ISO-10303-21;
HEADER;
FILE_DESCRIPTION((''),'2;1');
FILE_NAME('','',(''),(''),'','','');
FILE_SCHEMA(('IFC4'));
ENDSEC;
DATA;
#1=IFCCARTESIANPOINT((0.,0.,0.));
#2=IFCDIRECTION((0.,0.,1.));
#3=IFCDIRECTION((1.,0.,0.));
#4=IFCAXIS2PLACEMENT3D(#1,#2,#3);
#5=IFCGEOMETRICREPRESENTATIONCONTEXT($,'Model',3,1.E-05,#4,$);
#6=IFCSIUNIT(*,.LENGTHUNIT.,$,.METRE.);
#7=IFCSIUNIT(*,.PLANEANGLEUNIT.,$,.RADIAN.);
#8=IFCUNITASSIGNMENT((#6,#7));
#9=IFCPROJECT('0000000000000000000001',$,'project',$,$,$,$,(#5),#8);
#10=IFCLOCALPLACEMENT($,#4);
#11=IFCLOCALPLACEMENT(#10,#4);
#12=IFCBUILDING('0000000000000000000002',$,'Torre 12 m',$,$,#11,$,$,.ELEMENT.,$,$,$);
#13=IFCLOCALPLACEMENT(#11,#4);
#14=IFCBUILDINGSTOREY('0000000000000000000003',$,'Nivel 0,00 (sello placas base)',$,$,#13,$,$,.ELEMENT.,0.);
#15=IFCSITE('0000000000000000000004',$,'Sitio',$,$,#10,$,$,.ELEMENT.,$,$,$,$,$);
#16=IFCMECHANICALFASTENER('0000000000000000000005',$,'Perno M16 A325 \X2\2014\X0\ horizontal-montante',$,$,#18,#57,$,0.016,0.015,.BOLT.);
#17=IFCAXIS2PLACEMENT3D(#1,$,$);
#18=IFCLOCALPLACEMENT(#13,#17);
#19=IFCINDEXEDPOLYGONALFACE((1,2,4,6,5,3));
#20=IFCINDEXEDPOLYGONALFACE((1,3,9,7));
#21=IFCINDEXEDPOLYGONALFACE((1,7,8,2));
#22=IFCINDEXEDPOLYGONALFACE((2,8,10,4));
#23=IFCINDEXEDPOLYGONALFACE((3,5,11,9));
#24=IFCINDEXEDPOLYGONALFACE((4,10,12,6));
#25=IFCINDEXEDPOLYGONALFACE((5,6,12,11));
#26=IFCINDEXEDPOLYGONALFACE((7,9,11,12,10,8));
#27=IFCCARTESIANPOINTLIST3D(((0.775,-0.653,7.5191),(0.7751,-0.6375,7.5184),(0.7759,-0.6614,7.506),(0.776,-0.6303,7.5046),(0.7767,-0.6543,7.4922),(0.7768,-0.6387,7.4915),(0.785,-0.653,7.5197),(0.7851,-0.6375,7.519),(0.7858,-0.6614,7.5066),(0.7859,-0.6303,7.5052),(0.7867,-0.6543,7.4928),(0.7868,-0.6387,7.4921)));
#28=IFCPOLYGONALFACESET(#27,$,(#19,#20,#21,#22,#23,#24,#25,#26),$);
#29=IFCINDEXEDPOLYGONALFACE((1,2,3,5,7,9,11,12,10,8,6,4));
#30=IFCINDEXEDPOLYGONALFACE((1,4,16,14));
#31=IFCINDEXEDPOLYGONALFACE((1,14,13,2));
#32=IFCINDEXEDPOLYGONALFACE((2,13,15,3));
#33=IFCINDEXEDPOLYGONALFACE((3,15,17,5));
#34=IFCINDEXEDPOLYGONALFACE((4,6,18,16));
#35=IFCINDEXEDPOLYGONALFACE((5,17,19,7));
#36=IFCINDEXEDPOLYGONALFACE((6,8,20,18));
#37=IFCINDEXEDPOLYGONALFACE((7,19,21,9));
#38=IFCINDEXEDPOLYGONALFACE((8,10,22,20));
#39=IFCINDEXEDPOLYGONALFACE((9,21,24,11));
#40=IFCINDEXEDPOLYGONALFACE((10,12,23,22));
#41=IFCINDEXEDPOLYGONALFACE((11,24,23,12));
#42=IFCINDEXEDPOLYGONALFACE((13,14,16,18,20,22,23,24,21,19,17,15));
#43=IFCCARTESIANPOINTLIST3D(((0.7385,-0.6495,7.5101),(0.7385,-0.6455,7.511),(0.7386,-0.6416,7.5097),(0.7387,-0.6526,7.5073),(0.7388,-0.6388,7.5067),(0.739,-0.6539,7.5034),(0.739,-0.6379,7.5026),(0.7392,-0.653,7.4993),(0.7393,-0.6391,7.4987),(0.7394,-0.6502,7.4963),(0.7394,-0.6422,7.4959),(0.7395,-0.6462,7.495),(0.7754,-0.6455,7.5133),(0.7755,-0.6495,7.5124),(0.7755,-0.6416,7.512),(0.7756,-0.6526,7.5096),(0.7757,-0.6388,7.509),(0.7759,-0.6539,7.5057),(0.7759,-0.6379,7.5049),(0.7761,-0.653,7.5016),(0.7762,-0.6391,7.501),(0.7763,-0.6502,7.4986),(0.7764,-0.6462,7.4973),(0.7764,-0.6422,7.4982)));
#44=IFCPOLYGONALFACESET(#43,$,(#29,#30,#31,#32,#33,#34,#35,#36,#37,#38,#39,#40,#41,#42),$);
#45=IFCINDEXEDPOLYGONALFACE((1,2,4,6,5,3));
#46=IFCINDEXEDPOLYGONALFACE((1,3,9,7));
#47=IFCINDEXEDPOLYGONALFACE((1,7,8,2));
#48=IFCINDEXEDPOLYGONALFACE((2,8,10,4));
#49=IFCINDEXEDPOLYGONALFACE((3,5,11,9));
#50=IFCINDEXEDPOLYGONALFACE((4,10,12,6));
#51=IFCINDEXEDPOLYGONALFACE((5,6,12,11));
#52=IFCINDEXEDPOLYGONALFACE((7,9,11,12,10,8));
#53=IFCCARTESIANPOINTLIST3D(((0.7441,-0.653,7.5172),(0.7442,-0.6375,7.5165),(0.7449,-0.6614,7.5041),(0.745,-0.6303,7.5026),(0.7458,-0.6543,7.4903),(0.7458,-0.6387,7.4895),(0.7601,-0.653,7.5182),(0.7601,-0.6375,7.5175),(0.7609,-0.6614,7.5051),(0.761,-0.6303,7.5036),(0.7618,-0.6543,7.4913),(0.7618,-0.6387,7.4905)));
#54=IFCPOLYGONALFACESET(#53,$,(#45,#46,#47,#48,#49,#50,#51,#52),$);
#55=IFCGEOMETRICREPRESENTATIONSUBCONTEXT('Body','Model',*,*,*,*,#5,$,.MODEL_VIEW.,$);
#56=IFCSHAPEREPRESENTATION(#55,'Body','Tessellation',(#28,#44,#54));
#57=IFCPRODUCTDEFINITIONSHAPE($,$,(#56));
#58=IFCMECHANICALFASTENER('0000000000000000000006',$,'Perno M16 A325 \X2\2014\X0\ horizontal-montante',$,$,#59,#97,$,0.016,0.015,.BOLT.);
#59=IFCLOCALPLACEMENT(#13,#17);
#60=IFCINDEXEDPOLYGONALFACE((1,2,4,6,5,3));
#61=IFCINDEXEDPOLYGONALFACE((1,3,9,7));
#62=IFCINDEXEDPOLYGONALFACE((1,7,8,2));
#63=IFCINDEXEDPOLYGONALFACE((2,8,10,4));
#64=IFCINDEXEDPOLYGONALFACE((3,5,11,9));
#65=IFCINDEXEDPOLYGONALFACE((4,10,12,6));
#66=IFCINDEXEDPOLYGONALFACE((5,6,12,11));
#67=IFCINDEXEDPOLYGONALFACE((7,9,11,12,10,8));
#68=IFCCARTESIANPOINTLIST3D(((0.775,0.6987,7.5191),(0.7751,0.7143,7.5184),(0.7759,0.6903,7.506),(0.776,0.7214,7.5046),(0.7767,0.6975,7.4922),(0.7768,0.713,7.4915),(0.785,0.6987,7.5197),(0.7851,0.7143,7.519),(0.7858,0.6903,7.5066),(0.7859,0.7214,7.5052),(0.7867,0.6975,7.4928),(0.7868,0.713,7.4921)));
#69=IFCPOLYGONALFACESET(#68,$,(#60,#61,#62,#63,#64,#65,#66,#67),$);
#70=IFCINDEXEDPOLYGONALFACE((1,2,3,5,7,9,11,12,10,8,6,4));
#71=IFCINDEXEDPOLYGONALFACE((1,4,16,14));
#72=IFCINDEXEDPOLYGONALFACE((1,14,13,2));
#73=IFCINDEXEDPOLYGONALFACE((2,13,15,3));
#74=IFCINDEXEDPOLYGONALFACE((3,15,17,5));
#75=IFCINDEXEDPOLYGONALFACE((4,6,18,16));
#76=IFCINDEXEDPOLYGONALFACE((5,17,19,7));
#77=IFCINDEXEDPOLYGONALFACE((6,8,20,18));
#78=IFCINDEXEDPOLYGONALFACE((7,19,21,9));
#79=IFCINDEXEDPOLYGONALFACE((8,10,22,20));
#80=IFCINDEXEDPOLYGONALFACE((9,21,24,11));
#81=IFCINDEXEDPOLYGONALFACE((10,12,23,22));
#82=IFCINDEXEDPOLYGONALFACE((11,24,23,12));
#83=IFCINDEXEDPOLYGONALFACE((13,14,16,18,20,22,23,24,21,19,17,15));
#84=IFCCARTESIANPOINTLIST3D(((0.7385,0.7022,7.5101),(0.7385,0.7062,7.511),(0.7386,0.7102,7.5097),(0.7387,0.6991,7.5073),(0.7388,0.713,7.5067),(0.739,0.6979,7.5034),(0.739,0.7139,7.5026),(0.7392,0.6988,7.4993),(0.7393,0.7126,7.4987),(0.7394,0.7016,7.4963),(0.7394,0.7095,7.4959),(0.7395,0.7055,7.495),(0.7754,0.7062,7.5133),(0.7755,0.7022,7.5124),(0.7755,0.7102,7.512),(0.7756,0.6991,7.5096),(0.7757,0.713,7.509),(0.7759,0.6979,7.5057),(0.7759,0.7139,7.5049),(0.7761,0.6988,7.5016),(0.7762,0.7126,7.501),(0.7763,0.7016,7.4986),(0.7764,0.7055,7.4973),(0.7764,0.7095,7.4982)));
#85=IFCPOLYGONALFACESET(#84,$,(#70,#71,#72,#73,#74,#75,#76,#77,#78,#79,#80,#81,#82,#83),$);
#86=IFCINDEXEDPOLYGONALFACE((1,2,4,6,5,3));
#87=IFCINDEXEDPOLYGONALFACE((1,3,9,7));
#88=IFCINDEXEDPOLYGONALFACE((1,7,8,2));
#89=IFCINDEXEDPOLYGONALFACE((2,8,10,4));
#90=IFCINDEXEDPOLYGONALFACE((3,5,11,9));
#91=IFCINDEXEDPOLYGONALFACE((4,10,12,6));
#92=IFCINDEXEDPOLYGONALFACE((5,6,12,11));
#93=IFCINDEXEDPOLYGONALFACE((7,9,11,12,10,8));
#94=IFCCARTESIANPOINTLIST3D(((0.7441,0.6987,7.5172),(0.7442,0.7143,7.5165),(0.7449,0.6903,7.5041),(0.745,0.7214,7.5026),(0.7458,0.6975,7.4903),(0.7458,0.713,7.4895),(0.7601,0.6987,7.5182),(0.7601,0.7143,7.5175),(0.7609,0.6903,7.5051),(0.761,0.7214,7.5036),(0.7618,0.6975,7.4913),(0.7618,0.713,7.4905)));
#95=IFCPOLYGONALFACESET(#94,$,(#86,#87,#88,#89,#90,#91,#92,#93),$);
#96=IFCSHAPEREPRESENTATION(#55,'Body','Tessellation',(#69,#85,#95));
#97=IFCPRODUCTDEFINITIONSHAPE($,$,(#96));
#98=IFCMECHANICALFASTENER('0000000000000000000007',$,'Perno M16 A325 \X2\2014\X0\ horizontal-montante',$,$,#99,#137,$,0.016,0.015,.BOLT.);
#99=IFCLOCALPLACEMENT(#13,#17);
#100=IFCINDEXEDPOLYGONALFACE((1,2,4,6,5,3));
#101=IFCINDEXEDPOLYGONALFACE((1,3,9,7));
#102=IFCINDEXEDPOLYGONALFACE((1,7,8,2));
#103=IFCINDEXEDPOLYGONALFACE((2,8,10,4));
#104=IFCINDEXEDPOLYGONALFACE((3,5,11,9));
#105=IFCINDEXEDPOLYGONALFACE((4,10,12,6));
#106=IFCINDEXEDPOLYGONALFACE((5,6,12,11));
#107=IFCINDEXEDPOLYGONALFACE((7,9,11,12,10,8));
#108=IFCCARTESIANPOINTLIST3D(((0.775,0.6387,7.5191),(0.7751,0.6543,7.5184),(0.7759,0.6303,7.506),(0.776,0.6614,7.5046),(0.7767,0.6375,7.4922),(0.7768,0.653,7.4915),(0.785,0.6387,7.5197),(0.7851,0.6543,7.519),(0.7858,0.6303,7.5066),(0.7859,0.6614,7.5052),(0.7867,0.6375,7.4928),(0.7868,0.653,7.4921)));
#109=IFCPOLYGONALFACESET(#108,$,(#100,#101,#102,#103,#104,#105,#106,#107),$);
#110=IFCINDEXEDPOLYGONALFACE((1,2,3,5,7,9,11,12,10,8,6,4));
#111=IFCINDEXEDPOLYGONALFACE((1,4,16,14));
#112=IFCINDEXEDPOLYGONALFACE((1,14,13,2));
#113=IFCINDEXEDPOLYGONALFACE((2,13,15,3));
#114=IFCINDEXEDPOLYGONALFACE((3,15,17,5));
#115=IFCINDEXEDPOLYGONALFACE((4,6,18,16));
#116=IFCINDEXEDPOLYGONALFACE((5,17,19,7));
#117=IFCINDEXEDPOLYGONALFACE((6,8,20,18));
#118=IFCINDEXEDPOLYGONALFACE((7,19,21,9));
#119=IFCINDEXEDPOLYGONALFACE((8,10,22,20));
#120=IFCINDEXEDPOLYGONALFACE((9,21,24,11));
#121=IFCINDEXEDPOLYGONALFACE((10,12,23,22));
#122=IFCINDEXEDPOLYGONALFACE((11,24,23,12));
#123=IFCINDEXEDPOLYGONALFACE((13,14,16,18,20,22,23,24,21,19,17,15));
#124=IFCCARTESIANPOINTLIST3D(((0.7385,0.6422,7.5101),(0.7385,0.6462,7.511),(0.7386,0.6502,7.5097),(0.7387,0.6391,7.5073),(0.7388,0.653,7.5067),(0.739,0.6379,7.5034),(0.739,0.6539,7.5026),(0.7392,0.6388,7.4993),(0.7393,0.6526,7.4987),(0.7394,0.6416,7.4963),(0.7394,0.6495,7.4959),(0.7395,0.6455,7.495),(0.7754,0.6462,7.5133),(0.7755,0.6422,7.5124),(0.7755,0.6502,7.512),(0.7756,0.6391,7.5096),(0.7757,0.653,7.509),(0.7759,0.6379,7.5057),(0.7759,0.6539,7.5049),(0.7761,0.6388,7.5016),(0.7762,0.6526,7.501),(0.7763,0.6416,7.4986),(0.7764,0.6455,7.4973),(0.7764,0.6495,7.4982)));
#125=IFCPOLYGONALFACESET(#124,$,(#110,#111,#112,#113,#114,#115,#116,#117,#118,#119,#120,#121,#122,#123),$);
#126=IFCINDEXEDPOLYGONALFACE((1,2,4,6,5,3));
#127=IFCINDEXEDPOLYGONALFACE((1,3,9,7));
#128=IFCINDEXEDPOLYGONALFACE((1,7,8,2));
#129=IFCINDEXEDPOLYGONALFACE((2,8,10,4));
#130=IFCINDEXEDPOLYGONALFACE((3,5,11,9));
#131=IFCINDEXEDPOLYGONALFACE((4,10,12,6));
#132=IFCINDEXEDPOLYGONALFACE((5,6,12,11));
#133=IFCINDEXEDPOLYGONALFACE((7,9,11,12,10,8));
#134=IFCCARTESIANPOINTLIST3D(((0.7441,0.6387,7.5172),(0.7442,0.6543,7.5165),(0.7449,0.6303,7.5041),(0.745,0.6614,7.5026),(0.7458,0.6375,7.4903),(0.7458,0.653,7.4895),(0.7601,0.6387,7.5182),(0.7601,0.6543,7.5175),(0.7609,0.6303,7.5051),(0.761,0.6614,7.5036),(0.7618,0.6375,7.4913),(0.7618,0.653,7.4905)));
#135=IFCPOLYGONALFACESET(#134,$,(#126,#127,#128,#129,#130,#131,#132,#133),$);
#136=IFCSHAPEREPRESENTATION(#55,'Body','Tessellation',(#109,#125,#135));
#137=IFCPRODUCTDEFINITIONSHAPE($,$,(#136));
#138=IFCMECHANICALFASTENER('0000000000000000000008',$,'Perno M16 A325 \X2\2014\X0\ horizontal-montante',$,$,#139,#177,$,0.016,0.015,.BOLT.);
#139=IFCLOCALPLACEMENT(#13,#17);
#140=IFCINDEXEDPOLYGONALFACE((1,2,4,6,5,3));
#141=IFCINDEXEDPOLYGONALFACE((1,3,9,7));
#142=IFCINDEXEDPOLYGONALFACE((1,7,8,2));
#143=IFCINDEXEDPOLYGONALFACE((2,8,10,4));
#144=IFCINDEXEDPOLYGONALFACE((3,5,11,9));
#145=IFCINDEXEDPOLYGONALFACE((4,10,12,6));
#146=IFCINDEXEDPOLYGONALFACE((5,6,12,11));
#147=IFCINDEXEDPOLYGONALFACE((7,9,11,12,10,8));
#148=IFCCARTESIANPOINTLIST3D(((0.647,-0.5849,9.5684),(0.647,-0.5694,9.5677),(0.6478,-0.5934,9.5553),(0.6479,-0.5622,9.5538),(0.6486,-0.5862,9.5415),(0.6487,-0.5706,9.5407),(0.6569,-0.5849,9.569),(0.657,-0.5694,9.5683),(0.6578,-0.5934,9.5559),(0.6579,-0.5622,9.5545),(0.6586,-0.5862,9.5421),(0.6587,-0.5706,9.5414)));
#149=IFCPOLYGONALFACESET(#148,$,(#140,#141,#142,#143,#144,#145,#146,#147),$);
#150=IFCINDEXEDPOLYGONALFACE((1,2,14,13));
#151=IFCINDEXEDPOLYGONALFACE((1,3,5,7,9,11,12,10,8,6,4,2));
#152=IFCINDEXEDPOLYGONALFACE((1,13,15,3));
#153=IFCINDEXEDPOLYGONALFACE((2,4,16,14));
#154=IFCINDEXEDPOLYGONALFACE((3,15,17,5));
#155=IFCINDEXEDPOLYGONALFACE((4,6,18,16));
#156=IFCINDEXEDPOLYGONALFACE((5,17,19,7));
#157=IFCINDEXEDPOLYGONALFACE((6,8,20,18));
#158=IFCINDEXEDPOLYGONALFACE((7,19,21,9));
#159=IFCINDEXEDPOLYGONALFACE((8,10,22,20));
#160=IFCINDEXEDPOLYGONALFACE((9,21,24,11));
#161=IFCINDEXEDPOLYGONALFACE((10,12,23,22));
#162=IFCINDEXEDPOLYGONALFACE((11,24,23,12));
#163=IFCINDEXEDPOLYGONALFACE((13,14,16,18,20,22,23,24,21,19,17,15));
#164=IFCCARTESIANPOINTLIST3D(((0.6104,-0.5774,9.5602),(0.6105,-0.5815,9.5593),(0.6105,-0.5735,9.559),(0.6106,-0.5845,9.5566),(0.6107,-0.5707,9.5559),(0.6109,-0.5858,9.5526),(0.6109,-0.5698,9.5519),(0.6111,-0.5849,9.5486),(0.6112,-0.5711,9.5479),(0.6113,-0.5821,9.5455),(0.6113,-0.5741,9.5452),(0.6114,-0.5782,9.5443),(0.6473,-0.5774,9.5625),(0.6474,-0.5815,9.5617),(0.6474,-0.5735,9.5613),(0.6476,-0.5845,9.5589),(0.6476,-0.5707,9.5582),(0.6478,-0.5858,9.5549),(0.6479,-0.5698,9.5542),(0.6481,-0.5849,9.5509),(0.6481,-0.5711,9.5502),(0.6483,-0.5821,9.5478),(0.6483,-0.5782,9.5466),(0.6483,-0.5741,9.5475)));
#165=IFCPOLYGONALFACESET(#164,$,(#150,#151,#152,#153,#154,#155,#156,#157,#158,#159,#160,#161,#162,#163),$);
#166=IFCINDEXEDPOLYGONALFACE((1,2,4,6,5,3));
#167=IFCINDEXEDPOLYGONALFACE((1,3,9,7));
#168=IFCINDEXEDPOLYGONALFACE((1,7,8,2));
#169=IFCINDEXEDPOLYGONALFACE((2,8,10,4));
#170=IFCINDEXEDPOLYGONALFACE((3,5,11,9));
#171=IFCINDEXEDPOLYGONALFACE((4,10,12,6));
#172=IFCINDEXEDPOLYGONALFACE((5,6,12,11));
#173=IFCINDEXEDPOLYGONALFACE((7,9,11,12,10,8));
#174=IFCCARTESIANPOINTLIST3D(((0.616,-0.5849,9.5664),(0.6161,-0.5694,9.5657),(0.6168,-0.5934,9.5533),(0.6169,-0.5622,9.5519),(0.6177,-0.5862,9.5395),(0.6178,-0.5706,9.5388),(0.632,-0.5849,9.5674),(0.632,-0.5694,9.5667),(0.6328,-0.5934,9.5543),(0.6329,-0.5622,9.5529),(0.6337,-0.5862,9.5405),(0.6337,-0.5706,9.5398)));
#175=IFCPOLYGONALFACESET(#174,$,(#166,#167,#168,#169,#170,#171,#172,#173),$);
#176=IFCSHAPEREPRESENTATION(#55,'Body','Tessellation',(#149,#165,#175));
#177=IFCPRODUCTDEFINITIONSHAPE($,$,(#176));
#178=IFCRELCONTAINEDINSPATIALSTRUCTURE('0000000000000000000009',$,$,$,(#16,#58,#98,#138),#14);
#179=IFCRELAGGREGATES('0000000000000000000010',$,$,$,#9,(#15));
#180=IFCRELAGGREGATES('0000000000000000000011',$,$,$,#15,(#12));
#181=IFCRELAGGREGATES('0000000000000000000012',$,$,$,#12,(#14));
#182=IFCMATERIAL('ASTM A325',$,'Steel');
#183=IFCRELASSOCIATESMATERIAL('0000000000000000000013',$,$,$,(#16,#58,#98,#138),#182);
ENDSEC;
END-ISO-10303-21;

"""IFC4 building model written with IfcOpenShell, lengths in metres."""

from ifc_helpers import new_model, si_unit, frame, origin_with_axes, place, context, subcontext, project, spatial, polyline, outline, extrude, material, element, save


model = new_model("IFC4")

# Units and contexts
model_context = context("Model", 3, precision=1e-05, world=origin_with_axes())
body_context = subcontext(model_context, "Body", "Model", "MODEL_VIEW")
ifc_project = project(units=[si_unit("LENGTHUNIT", "METRE"), si_unit("PLANEANGLEUNIT", "RADIAN")], contexts=[model_context])

# Site, building, storey
site_placement = place(None, origin_with_axes())
site = spatial("IfcSite", under=ifc_project, at=site_placement, Name="Sitio", CompositionType="ELEMENT")
building_placement = place(site_placement, origin_with_axes())
building = spatial("IfcBuilding", under=site, at=building_placement, Name="Torre 12 m", CompositionType="ELEMENT")
storey_placement = place(building_placement, origin_with_axes())
storey = spatial("IfcBuildingStorey", under=building, at=storey_placement, Name="Nivel 0,00 (sello placas base)", CompositionType="ELEMENT", Elevation=0.0)

# Shared definitions
placement = place(storey_placement, origin_with_axes())

# Mechanical fasteners
ifc_material_1 = material(Name="ASTM A325", Category="Steel")
element("IfcMechanicalFastener", 1, at=placement, inside=storey, material=ifc_material_1, Name="Perno M16 A325 — horizontal-montante", NominalDiameter=0.016, NominalLength=0.015, PredefinedType="BOLT", context=body_context, shape_type="SweptSolid", body=[
    extrude(outline(polyline([(0.0135, 0.0078), (0.0, 0.0156), (-0.0135, 0.0078), (-0.0135, -0.0078), (0.0, -0.0156), (0.0135, -0.0078), (0.0135, 0.0078)])), frame((0.7859, -0.6459, 7.5059), z_axis=(-0.998053, 0.0, -0.062378), x_axis=(0.033672, 0.841794, -0.538748)), (0.0, 0.0, 1.0), 0.01),
    extrude(outline(polyline([(0.008, 0.0), (0.0069, 0.004), (0.004, 0.0069), (0.0, 0.008), (-0.004, 0.0069), (-0.0069, 0.004), (-0.008, 0.0), (-0.0069, -0.004), (-0.004, -0.0069), (0.0, -0.008), (0.004, -0.0069), (0.0069, -0.004), (0.008, 0.0)])), frame((0.7759, -0.6459, 7.5053), z_axis=(-0.998053, 0.0, -0.062378), x_axis=(0.033672, 0.841794, -0.538748)), (0.0, 0.0, 1.0), 0.037),
    extrude(outline(polyline([(0.0135, 0.0078), (0.0, 0.0156), (-0.0135, 0.0078), (-0.0135, -0.0078), (0.0, -0.0156), (0.0135, -0.0078), (0.0135, 0.0078)])), frame((0.7609, -0.6459, 7.5044), z_axis=(-0.998053, 0.0, -0.062378), x_axis=(0.033672, 0.841794, -0.538748)), (0.0, 0.0, 1.0), 0.016),
])
element("IfcMechanicalFastener", 2, at=placement, inside=storey, material=ifc_material_1, Name="Perno M16 A325 — horizontal-montante", NominalDiameter=0.016, NominalLength=0.015, PredefinedType="BOLT", context=body_context, shape_type="SweptSolid", body=[
    extrude(outline(polyline([(0.0135, 0.0078), (0.0, 0.0156), (-0.0135, 0.0078), (-0.0135, -0.0078), (0.0, -0.0156), (0.0135, -0.0078), (0.0135, 0.0078)])), frame((0.7859, 0.7059, 7.5059), z_axis=(-0.998053, 0.0, -0.062378), x_axis=(0.033672, 0.841794, -0.538748)), (0.0, 0.0, 1.0), 0.01),
    extrude(outline(polyline([(0.008, 0.0), (0.0069, 0.004), (0.004, 0.0069), (0.0, 0.008), (-0.004, 0.0069), (-0.0069, 0.004), (-0.008, 0.0), (-0.0069, -0.004), (-0.004, -0.0069), (0.0, -0.008), (0.004, -0.0069), (0.0069, -0.004), (0.008, 0.0)])), frame((0.7759, 0.7059, 7.5053), z_axis=(-0.998053, 0.0, -0.062378), x_axis=(0.033672, 0.841794, -0.538748)), (0.0, 0.0, 1.0), 0.037),
    extrude(outline(polyline([(0.0135, 0.0078), (0.0, 0.0156), (-0.0135, 0.0078), (-0.0135, -0.0078), (0.0, -0.0156), (0.0135, -0.0078), (0.0135, 0.0078)])), frame((0.7609, 0.7059, 7.5044), z_axis=(-0.998053, 0.0, -0.062378), x_axis=(0.033672, 0.841794, -0.538748)), (0.0, 0.0, 1.0), 0.016),
])
element("IfcMechanicalFastener", 3, at=placement, inside=storey, material=ifc_material_1, Name="Perno M16 A325 — horizontal-montante", NominalDiameter=0.016, NominalLength=0.015, PredefinedType="BOLT", context=body_context, shape_type="SweptSolid", body=[
    extrude(outline(polyline([(0.0135, 0.0078), (0.0, 0.0156), (-0.0135, 0.0078), (-0.0135, -0.0078), (0.0, -0.0156), (0.0135, -0.0078), (0.0135, 0.0078)])), frame((0.7859, 0.6459, 7.5059), z_axis=(-0.998053, 0.0, -0.062378), x_axis=(0.033672, 0.841794, -0.538748)), (0.0, 0.0, 1.0), 0.01),
    extrude(outline(polyline([(0.008, 0.0), (0.0069, 0.004), (0.004, 0.0069), (0.0, 0.008), (-0.004, 0.0069), (-0.0069, 0.004), (-0.008, 0.0), (-0.0069, -0.004), (-0.004, -0.0069), (0.0, -0.008), (0.004, -0.0069), (0.0069, -0.004), (0.008, 0.0)])), frame((0.7759, 0.6459, 7.5053), z_axis=(-0.998053, 0.0, -0.062378), x_axis=(0.033672, 0.841794, -0.538748)), (0.0, 0.0, 1.0), 0.037),
    extrude(outline(polyline([(0.0135, 0.0078), (0.0, 0.0156), (-0.0135, 0.0078), (-0.0135, -0.0078), (0.0, -0.0156), (0.0135, -0.0078), (0.0135, 0.0078)])), frame((0.7609, 0.6459, 7.5044), z_axis=(-0.998053, 0.0, -0.062378), x_axis=(0.033672, 0.841794, -0.538748)), (0.0, 0.0, 1.0), 0.016),
])
element("IfcMechanicalFastener", 4, at=placement, inside=storey, material=ifc_material_1, Name="Perno M16 A325 — horizontal-montante", NominalDiameter=0.016, NominalLength=0.015, PredefinedType="BOLT", context=body_context, shape_type="SweptSolid", body=[
    extrude(outline(polyline([(0.0135, 0.0078), (0.0, 0.0156), (-0.0135, 0.0078), (-0.0135, -0.0078), (0.0, -0.0156), (0.0135, -0.0078), (0.0135, 0.0078)])), frame((0.6578, -0.5778, 9.5552), z_axis=(-0.998053, 0.0, -0.062378), x_axis=(0.033672, 0.841794, -0.538748)), (0.0, 0.0, 1.0), 0.01),
    extrude(outline(polyline([(0.008, 0.0), (0.0069, 0.004), (0.004, 0.0069), (0.0, 0.008), (-0.004, 0.0069), (-0.0069, 0.004), (-0.008, 0.0), (-0.0069, -0.004), (-0.004, -0.0069), (0.0, -0.008), (0.004, -0.0069), (0.0069, -0.004), (0.008, 0.0)])), frame((0.6478, -0.5778, 9.5546), z_axis=(-0.998053, 0.0, -0.062378), x_axis=(0.033672, 0.841794, -0.538748)), (0.0, 0.0, 1.0), 0.037),
    extrude(outline(polyline([(0.0135, 0.0078), (0.0, 0.0156), (-0.0135, 0.0078), (-0.0135, -0.0078), (0.0, -0.0156), (0.0135, -0.0078), (0.0135, 0.0078)])), frame((0.6329, -0.5778, 9.5536), z_axis=(-0.998053, 0.0, -0.062378), x_axis=(0.033672, 0.841794, -0.538748)), (0.0, 0.0, 1.0), 0.016),
])

save(model, "model.ifc")
